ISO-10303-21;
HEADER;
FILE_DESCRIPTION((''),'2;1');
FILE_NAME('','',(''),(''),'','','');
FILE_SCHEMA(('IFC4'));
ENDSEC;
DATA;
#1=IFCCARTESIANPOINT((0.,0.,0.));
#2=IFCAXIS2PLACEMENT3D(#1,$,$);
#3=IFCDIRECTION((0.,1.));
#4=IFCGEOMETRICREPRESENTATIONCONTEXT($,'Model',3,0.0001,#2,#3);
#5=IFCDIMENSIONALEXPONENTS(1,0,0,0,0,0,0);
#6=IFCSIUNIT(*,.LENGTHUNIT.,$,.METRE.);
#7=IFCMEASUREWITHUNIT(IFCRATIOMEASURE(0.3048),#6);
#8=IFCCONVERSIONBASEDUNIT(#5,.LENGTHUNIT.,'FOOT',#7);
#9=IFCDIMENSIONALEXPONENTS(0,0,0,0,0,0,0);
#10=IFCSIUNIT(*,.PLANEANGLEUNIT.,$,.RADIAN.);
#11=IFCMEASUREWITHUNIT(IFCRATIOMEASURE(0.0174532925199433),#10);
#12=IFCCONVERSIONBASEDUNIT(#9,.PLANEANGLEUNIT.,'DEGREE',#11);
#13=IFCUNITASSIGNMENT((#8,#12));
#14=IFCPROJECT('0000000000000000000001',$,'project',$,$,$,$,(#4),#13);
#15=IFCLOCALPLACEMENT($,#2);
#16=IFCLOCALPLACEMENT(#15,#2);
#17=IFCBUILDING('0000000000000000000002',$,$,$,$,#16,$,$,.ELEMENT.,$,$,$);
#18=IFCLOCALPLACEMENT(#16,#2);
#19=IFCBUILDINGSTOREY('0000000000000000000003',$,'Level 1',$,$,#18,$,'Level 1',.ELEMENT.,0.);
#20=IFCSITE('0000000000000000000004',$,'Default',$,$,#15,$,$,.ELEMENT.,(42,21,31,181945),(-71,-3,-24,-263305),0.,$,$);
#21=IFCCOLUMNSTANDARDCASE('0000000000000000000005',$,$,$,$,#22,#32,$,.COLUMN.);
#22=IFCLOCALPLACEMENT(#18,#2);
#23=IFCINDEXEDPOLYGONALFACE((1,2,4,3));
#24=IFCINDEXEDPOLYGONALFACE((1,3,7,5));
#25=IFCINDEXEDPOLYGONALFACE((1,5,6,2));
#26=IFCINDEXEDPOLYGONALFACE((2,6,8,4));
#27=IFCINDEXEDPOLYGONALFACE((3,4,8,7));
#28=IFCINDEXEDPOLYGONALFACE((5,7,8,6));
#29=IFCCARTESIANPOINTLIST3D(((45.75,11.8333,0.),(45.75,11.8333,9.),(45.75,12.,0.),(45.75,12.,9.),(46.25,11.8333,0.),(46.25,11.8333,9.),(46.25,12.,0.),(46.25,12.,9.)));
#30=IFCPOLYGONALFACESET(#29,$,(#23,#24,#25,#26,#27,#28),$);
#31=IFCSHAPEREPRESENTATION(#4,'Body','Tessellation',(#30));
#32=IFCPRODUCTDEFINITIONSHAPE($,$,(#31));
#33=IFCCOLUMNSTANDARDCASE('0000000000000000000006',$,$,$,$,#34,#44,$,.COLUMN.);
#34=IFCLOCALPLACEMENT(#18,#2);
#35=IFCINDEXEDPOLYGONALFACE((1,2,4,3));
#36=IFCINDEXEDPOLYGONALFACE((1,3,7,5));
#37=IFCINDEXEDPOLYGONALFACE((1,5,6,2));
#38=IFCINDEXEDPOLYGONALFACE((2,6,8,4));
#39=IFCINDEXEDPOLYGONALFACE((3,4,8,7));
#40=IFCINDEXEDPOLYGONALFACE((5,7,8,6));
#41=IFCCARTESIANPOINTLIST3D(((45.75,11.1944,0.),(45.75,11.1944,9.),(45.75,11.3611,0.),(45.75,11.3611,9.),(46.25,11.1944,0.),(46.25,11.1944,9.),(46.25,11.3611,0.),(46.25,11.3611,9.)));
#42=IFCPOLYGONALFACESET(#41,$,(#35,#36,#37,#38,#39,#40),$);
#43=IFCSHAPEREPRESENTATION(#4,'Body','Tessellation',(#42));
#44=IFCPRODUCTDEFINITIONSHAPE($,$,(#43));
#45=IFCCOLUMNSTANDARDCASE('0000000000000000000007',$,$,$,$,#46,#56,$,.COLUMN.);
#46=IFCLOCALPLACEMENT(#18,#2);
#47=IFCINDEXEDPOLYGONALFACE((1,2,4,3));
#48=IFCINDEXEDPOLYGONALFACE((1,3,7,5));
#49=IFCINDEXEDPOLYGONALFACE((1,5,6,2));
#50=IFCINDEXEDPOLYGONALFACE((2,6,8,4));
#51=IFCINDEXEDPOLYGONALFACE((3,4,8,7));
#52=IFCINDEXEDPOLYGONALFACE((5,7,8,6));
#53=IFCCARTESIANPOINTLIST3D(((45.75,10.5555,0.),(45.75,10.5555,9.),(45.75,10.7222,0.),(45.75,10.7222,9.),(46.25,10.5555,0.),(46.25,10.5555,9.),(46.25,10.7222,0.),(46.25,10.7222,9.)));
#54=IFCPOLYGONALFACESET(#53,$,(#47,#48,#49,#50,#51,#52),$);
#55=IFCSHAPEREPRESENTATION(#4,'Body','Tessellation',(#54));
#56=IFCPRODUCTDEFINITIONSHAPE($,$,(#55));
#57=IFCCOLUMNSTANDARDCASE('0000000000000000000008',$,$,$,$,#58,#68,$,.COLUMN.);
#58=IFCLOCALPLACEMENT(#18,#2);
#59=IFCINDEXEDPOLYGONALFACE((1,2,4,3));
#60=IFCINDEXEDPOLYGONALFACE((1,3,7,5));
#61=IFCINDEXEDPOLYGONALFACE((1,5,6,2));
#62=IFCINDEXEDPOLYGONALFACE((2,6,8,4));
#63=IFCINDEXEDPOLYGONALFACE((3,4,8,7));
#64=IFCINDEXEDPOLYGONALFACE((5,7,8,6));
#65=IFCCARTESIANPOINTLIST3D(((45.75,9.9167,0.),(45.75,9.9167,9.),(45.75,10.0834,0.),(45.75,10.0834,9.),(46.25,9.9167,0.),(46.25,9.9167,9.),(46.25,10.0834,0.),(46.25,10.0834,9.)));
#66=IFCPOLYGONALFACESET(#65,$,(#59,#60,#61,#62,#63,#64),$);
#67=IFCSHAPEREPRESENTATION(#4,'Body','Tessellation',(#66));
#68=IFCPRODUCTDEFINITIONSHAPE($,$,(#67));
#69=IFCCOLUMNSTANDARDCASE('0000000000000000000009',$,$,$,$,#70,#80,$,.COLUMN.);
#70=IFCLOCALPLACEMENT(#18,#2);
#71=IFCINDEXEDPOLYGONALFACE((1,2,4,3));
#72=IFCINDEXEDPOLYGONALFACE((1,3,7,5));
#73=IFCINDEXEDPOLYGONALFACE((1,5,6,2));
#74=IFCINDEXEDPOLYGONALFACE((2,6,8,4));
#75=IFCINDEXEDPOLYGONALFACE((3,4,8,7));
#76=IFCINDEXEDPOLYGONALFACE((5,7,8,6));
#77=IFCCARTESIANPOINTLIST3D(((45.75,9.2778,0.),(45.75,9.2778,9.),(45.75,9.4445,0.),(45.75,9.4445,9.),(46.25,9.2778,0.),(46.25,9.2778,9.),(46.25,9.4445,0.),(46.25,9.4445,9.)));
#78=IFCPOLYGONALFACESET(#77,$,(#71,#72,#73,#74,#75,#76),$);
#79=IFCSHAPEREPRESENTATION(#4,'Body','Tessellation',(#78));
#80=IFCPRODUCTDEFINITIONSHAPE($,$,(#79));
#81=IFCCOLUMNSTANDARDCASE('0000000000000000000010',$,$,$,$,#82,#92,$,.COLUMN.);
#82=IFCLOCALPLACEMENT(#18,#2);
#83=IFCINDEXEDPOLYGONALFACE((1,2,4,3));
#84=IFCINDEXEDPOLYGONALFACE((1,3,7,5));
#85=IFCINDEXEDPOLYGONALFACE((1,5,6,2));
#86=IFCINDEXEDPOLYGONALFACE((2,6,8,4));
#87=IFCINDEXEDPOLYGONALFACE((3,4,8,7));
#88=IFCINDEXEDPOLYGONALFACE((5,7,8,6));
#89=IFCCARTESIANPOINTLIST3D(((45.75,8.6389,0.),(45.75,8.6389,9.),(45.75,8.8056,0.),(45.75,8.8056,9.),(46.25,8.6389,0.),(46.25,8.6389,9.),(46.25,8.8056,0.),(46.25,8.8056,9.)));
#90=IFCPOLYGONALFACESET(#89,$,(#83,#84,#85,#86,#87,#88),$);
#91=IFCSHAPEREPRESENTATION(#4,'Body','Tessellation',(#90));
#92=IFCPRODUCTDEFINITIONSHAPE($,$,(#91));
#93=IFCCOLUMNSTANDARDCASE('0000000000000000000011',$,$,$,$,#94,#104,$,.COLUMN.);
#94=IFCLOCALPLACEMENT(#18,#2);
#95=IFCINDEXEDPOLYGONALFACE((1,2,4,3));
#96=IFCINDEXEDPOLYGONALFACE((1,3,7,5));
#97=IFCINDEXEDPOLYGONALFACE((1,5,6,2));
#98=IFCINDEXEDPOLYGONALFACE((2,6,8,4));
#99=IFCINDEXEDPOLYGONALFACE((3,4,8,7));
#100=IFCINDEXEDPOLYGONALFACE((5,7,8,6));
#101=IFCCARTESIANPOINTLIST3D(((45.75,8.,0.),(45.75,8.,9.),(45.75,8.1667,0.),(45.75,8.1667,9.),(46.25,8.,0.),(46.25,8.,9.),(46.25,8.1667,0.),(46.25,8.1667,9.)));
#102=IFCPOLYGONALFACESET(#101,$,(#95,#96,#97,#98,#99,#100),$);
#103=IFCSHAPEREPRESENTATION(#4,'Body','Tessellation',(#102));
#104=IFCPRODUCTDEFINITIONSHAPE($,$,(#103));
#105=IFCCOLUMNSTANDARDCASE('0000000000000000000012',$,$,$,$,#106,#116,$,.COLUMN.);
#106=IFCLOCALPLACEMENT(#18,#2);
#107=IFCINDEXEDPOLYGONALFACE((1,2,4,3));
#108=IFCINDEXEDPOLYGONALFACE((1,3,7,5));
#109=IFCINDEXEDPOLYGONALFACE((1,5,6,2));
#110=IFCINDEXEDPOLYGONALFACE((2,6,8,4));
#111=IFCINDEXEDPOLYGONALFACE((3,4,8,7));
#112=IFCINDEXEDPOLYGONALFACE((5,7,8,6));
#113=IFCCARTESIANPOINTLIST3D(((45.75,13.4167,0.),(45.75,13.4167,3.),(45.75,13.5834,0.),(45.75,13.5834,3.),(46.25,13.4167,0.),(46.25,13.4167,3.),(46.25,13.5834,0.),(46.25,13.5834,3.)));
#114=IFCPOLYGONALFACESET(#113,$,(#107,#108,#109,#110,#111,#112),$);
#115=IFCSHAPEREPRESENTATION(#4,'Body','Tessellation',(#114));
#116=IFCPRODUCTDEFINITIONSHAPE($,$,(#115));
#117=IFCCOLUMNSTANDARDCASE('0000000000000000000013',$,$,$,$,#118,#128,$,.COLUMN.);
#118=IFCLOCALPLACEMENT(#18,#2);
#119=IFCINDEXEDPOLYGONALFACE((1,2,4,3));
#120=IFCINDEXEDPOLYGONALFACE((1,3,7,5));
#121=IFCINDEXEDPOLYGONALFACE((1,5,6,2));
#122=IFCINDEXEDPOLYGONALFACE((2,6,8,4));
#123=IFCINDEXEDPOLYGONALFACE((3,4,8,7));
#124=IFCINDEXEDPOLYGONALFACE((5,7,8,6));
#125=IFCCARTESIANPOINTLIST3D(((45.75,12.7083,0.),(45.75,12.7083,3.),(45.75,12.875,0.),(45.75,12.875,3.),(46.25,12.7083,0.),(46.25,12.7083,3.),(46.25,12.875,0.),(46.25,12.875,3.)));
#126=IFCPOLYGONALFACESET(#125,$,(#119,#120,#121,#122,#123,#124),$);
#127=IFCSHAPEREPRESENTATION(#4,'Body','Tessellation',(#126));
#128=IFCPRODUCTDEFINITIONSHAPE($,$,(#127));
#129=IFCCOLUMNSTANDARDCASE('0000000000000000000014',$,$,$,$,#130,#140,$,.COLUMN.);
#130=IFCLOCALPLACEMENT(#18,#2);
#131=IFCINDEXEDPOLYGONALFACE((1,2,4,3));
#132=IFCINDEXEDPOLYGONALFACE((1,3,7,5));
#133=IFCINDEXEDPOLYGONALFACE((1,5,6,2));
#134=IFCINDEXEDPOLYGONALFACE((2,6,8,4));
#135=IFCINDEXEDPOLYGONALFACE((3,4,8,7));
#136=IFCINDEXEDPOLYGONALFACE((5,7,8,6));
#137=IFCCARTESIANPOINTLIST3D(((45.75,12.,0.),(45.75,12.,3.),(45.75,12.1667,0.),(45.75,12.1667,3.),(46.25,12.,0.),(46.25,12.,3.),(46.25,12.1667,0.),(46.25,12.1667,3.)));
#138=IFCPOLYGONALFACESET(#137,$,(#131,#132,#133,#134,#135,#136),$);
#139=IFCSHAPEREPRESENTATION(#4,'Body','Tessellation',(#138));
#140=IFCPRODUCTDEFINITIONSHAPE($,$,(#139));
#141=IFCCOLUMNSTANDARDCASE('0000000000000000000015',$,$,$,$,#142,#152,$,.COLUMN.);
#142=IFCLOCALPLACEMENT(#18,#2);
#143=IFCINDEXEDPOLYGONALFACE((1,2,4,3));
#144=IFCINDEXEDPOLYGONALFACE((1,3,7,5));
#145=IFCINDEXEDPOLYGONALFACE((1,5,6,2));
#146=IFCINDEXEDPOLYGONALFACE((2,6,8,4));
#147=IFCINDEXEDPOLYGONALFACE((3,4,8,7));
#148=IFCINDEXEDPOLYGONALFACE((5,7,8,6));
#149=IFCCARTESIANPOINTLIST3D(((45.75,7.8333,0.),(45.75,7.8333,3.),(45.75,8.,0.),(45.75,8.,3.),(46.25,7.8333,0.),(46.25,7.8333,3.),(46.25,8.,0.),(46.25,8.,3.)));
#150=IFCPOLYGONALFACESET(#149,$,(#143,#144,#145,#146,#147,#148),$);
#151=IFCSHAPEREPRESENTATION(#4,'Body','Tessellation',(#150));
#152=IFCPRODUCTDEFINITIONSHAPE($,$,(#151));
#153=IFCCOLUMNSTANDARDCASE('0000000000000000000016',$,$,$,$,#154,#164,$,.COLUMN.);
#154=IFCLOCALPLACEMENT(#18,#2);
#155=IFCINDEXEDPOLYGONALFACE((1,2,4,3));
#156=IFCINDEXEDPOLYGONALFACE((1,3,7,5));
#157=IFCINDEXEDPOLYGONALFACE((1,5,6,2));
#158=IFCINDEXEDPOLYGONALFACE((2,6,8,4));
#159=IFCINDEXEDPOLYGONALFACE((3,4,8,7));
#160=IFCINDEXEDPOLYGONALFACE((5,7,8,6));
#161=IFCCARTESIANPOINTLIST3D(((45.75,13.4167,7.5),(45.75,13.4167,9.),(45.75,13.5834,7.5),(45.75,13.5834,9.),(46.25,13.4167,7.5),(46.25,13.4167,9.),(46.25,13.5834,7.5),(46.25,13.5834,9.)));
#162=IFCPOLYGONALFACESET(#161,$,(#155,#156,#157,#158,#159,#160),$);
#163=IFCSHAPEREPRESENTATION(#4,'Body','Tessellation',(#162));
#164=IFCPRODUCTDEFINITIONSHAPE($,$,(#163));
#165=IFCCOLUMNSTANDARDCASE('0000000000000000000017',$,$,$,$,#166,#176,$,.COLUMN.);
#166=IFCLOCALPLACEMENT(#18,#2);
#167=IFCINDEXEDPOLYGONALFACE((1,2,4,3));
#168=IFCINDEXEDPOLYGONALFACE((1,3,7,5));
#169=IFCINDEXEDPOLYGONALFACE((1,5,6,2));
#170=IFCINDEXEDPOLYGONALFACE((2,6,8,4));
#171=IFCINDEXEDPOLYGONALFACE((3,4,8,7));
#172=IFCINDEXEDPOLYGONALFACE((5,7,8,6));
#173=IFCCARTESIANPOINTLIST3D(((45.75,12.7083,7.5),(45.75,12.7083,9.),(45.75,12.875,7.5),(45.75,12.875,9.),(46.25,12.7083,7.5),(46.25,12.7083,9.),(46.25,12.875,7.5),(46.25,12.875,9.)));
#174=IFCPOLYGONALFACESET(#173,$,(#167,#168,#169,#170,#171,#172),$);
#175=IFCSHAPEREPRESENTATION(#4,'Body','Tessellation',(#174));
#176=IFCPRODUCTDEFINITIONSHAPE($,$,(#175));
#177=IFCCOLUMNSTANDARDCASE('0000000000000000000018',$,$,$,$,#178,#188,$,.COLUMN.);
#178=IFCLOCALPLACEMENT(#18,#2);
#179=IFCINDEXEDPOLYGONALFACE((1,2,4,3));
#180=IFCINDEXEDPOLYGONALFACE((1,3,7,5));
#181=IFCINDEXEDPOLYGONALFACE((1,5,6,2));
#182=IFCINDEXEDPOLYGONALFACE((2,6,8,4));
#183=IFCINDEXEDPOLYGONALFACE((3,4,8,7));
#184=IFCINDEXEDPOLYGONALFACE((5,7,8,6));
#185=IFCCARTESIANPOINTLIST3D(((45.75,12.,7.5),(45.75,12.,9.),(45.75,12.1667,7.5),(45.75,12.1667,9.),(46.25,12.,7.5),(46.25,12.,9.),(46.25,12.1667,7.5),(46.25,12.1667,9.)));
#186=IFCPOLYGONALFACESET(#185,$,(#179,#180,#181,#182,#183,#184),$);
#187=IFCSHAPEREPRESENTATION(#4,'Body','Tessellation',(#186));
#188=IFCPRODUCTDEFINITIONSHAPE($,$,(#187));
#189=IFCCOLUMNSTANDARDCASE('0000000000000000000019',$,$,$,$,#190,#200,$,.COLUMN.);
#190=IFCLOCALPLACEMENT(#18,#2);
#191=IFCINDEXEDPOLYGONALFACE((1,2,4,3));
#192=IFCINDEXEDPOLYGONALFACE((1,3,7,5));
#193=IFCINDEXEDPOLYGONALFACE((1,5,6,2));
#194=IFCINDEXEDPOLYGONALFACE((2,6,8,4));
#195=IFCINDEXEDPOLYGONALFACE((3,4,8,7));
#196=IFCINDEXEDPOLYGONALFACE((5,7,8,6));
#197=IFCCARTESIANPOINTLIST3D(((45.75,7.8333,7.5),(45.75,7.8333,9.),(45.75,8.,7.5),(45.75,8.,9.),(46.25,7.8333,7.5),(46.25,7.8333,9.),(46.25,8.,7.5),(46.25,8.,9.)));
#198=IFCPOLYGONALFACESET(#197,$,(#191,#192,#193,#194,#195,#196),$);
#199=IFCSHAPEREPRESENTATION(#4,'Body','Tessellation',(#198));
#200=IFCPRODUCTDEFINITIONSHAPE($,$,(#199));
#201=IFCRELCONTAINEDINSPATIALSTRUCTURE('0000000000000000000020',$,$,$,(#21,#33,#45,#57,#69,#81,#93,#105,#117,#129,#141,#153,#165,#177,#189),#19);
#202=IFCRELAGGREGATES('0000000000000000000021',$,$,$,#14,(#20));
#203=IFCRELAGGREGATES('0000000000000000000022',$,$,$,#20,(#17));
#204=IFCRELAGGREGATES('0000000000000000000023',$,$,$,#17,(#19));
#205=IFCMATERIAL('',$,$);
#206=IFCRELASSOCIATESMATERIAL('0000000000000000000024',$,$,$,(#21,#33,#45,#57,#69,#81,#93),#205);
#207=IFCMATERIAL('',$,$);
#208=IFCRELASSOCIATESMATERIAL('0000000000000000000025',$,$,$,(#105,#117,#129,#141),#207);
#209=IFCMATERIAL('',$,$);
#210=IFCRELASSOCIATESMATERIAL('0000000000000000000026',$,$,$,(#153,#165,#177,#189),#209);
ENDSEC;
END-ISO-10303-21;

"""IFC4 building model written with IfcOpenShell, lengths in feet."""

from ifc_helpers import new_model, entity, si_unit, converted_unit, direction, frame, origin, place, context, project, spatial, rectangle, extrude, material, element, save


model = new_model("IFC4")

# Units and contexts
model_context = context("Model", 3, precision=0.0001, world=origin(), true_north=direction((0.0, 1.0)))
ifc_project = project(units=[converted_unit("LENGTHUNIT", "FOOT", entity("IfcRatioMeasure", 0.3048), si_unit("LENGTHUNIT", "METRE"), dimensions=[1, 0, 0, 0, 0, 0, 0]), converted_unit("PLANEANGLEUNIT", "DEGREE", entity("IfcRatioMeasure", 0.0174532925199433), si_unit("PLANEANGLEUNIT", "RADIAN"), dimensions=[0, 0, 0, 0, 0, 0, 0])], contexts=[model_context])

# Site, building, storey
site_placement = place(None, origin())
site = spatial("IfcSite", under=ifc_project, at=site_placement, Name="Default", CompositionType="ELEMENT", RefLatitude=(42, 21, 31, 181945), RefLongitude=(-71, -3, -24, -263305), RefElevation=0.0)
building_placement = place(site_placement, origin())
building = spatial("IfcBuilding", under=site, at=building_placement, CompositionType="ELEMENT")
storey_placement = place(building_placement, origin())
storey = spatial("IfcBuildingStorey", under=building, at=storey_placement, Name="Level 1", LongName="Level 1", CompositionType="ELEMENT", Elevation=0.0)

# Columns
ifc_material_1 = material(Name="")
placement = place(storey_placement, frame((46.0, 46.25, 0.0), z_axis=(0.0, 0.0, 1.0), x_axis=(0.0, -1.0, 0.0)))
for number, where, z_axis, x_axis in (
    (1, (34.3334, 0.0, 0.0), (0.0, 0.0, 1.0), (1.0, 0.0, 0.0)),
    (2, (34.9722, 0.0, 0.0), (0.0, 0.0, 1.0), (1.0, 0.0, 0.0)),
    (3, (35.6111, 0.0, 0.0), (0.0, 0.0, 1.0), (1.0, 0.0, 0.0)),
    (4, (36.25, 0.0, 0.0), (0.0, 0.0, 1.0), (1.0, 0.0, 0.0)),
    (5, (36.8889, 0.0, 0.0), (0.0, 0.0, 1.0), (1.0, 0.0, 0.0)),
    (6, (37.5278, 0.0, 0.0), (0.0, 0.0, 1.0), (1.0, 0.0, 0.0)),
    (7, (38.1667, 0.0, 0.0), (0.0, 0.0, 1.0), (1.0, 0.0, 0.0)),
):
    element("IfcColumnStandardCase", number, at=place(placement, frame(where, z_axis=z_axis, x_axis=x_axis)), inside=storey, material=ifc_material_1, PredefinedType="COLUMN", context=model_context, shape_type="SweptSolid", body=[
        extrude(rectangle(XDim=0.1667, YDim=0.5), origin(), (0.0, 0.0, 1.0), 9.0),
    ])
ifc_material_2 = material(Name="")
for number, where, z_axis, x_axis in (
    (8, (32.75, 0.0, 0.0), (0.0, 0.0, 1.0), (1.0, 0.0, 0.0)),
    (9, (33.4583, 0.0, 0.0), (0.0, 0.0, 1.0), (1.0, 0.0, 0.0)),
    (10, (34.1667, 0.0, 0.0), (0.0, 0.0, 1.0), (1.0, 0.0, 0.0)),
    (11, (38.3334, 0.0, 0.0), (0.0, 0.0, 1.0), (1.0, 0.0, 0.0)),
):
    element("IfcColumnStandardCase", number, at=place(placement, frame(where, z_axis=z_axis, x_axis=x_axis)), inside=storey, material=ifc_material_2, PredefinedType="COLUMN", context=model_context, shape_type="SweptSolid", body=[
        extrude(rectangle(XDim=0.1667, YDim=0.5), origin(), (0.0, 0.0, 1.0), 3.0),
    ])
ifc_material_3 = material(Name="")
for number, where, z_axis, x_axis in (
    (12, (32.75, 0.0, 7.5), (0.0, 0.0, 1.0), (1.0, 0.0, 0.0)),
    (13, (33.4583, 0.0, 7.5), (0.0, 0.0, 1.0), (1.0, 0.0, 0.0)),
    (14, (34.1667, 0.0, 7.5), (0.0, 0.0, 1.0), (1.0, 0.0, 0.0)),
    (15, (38.3334, 0.0, 7.5), (0.0, 0.0, 1.0), (1.0, 0.0, 0.0)),
):
    element("IfcColumnStandardCase", number, at=place(placement, frame(where, z_axis=z_axis, x_axis=x_axis)), inside=storey, material=ifc_material_3, PredefinedType="COLUMN", context=model_context, shape_type="SweptSolid", body=[
        extrude(rectangle(XDim=0.1667, YDim=0.5), origin(), (0.0, 0.0, 1.0), 1.5),
    ])

save(model, "model.ifc")
